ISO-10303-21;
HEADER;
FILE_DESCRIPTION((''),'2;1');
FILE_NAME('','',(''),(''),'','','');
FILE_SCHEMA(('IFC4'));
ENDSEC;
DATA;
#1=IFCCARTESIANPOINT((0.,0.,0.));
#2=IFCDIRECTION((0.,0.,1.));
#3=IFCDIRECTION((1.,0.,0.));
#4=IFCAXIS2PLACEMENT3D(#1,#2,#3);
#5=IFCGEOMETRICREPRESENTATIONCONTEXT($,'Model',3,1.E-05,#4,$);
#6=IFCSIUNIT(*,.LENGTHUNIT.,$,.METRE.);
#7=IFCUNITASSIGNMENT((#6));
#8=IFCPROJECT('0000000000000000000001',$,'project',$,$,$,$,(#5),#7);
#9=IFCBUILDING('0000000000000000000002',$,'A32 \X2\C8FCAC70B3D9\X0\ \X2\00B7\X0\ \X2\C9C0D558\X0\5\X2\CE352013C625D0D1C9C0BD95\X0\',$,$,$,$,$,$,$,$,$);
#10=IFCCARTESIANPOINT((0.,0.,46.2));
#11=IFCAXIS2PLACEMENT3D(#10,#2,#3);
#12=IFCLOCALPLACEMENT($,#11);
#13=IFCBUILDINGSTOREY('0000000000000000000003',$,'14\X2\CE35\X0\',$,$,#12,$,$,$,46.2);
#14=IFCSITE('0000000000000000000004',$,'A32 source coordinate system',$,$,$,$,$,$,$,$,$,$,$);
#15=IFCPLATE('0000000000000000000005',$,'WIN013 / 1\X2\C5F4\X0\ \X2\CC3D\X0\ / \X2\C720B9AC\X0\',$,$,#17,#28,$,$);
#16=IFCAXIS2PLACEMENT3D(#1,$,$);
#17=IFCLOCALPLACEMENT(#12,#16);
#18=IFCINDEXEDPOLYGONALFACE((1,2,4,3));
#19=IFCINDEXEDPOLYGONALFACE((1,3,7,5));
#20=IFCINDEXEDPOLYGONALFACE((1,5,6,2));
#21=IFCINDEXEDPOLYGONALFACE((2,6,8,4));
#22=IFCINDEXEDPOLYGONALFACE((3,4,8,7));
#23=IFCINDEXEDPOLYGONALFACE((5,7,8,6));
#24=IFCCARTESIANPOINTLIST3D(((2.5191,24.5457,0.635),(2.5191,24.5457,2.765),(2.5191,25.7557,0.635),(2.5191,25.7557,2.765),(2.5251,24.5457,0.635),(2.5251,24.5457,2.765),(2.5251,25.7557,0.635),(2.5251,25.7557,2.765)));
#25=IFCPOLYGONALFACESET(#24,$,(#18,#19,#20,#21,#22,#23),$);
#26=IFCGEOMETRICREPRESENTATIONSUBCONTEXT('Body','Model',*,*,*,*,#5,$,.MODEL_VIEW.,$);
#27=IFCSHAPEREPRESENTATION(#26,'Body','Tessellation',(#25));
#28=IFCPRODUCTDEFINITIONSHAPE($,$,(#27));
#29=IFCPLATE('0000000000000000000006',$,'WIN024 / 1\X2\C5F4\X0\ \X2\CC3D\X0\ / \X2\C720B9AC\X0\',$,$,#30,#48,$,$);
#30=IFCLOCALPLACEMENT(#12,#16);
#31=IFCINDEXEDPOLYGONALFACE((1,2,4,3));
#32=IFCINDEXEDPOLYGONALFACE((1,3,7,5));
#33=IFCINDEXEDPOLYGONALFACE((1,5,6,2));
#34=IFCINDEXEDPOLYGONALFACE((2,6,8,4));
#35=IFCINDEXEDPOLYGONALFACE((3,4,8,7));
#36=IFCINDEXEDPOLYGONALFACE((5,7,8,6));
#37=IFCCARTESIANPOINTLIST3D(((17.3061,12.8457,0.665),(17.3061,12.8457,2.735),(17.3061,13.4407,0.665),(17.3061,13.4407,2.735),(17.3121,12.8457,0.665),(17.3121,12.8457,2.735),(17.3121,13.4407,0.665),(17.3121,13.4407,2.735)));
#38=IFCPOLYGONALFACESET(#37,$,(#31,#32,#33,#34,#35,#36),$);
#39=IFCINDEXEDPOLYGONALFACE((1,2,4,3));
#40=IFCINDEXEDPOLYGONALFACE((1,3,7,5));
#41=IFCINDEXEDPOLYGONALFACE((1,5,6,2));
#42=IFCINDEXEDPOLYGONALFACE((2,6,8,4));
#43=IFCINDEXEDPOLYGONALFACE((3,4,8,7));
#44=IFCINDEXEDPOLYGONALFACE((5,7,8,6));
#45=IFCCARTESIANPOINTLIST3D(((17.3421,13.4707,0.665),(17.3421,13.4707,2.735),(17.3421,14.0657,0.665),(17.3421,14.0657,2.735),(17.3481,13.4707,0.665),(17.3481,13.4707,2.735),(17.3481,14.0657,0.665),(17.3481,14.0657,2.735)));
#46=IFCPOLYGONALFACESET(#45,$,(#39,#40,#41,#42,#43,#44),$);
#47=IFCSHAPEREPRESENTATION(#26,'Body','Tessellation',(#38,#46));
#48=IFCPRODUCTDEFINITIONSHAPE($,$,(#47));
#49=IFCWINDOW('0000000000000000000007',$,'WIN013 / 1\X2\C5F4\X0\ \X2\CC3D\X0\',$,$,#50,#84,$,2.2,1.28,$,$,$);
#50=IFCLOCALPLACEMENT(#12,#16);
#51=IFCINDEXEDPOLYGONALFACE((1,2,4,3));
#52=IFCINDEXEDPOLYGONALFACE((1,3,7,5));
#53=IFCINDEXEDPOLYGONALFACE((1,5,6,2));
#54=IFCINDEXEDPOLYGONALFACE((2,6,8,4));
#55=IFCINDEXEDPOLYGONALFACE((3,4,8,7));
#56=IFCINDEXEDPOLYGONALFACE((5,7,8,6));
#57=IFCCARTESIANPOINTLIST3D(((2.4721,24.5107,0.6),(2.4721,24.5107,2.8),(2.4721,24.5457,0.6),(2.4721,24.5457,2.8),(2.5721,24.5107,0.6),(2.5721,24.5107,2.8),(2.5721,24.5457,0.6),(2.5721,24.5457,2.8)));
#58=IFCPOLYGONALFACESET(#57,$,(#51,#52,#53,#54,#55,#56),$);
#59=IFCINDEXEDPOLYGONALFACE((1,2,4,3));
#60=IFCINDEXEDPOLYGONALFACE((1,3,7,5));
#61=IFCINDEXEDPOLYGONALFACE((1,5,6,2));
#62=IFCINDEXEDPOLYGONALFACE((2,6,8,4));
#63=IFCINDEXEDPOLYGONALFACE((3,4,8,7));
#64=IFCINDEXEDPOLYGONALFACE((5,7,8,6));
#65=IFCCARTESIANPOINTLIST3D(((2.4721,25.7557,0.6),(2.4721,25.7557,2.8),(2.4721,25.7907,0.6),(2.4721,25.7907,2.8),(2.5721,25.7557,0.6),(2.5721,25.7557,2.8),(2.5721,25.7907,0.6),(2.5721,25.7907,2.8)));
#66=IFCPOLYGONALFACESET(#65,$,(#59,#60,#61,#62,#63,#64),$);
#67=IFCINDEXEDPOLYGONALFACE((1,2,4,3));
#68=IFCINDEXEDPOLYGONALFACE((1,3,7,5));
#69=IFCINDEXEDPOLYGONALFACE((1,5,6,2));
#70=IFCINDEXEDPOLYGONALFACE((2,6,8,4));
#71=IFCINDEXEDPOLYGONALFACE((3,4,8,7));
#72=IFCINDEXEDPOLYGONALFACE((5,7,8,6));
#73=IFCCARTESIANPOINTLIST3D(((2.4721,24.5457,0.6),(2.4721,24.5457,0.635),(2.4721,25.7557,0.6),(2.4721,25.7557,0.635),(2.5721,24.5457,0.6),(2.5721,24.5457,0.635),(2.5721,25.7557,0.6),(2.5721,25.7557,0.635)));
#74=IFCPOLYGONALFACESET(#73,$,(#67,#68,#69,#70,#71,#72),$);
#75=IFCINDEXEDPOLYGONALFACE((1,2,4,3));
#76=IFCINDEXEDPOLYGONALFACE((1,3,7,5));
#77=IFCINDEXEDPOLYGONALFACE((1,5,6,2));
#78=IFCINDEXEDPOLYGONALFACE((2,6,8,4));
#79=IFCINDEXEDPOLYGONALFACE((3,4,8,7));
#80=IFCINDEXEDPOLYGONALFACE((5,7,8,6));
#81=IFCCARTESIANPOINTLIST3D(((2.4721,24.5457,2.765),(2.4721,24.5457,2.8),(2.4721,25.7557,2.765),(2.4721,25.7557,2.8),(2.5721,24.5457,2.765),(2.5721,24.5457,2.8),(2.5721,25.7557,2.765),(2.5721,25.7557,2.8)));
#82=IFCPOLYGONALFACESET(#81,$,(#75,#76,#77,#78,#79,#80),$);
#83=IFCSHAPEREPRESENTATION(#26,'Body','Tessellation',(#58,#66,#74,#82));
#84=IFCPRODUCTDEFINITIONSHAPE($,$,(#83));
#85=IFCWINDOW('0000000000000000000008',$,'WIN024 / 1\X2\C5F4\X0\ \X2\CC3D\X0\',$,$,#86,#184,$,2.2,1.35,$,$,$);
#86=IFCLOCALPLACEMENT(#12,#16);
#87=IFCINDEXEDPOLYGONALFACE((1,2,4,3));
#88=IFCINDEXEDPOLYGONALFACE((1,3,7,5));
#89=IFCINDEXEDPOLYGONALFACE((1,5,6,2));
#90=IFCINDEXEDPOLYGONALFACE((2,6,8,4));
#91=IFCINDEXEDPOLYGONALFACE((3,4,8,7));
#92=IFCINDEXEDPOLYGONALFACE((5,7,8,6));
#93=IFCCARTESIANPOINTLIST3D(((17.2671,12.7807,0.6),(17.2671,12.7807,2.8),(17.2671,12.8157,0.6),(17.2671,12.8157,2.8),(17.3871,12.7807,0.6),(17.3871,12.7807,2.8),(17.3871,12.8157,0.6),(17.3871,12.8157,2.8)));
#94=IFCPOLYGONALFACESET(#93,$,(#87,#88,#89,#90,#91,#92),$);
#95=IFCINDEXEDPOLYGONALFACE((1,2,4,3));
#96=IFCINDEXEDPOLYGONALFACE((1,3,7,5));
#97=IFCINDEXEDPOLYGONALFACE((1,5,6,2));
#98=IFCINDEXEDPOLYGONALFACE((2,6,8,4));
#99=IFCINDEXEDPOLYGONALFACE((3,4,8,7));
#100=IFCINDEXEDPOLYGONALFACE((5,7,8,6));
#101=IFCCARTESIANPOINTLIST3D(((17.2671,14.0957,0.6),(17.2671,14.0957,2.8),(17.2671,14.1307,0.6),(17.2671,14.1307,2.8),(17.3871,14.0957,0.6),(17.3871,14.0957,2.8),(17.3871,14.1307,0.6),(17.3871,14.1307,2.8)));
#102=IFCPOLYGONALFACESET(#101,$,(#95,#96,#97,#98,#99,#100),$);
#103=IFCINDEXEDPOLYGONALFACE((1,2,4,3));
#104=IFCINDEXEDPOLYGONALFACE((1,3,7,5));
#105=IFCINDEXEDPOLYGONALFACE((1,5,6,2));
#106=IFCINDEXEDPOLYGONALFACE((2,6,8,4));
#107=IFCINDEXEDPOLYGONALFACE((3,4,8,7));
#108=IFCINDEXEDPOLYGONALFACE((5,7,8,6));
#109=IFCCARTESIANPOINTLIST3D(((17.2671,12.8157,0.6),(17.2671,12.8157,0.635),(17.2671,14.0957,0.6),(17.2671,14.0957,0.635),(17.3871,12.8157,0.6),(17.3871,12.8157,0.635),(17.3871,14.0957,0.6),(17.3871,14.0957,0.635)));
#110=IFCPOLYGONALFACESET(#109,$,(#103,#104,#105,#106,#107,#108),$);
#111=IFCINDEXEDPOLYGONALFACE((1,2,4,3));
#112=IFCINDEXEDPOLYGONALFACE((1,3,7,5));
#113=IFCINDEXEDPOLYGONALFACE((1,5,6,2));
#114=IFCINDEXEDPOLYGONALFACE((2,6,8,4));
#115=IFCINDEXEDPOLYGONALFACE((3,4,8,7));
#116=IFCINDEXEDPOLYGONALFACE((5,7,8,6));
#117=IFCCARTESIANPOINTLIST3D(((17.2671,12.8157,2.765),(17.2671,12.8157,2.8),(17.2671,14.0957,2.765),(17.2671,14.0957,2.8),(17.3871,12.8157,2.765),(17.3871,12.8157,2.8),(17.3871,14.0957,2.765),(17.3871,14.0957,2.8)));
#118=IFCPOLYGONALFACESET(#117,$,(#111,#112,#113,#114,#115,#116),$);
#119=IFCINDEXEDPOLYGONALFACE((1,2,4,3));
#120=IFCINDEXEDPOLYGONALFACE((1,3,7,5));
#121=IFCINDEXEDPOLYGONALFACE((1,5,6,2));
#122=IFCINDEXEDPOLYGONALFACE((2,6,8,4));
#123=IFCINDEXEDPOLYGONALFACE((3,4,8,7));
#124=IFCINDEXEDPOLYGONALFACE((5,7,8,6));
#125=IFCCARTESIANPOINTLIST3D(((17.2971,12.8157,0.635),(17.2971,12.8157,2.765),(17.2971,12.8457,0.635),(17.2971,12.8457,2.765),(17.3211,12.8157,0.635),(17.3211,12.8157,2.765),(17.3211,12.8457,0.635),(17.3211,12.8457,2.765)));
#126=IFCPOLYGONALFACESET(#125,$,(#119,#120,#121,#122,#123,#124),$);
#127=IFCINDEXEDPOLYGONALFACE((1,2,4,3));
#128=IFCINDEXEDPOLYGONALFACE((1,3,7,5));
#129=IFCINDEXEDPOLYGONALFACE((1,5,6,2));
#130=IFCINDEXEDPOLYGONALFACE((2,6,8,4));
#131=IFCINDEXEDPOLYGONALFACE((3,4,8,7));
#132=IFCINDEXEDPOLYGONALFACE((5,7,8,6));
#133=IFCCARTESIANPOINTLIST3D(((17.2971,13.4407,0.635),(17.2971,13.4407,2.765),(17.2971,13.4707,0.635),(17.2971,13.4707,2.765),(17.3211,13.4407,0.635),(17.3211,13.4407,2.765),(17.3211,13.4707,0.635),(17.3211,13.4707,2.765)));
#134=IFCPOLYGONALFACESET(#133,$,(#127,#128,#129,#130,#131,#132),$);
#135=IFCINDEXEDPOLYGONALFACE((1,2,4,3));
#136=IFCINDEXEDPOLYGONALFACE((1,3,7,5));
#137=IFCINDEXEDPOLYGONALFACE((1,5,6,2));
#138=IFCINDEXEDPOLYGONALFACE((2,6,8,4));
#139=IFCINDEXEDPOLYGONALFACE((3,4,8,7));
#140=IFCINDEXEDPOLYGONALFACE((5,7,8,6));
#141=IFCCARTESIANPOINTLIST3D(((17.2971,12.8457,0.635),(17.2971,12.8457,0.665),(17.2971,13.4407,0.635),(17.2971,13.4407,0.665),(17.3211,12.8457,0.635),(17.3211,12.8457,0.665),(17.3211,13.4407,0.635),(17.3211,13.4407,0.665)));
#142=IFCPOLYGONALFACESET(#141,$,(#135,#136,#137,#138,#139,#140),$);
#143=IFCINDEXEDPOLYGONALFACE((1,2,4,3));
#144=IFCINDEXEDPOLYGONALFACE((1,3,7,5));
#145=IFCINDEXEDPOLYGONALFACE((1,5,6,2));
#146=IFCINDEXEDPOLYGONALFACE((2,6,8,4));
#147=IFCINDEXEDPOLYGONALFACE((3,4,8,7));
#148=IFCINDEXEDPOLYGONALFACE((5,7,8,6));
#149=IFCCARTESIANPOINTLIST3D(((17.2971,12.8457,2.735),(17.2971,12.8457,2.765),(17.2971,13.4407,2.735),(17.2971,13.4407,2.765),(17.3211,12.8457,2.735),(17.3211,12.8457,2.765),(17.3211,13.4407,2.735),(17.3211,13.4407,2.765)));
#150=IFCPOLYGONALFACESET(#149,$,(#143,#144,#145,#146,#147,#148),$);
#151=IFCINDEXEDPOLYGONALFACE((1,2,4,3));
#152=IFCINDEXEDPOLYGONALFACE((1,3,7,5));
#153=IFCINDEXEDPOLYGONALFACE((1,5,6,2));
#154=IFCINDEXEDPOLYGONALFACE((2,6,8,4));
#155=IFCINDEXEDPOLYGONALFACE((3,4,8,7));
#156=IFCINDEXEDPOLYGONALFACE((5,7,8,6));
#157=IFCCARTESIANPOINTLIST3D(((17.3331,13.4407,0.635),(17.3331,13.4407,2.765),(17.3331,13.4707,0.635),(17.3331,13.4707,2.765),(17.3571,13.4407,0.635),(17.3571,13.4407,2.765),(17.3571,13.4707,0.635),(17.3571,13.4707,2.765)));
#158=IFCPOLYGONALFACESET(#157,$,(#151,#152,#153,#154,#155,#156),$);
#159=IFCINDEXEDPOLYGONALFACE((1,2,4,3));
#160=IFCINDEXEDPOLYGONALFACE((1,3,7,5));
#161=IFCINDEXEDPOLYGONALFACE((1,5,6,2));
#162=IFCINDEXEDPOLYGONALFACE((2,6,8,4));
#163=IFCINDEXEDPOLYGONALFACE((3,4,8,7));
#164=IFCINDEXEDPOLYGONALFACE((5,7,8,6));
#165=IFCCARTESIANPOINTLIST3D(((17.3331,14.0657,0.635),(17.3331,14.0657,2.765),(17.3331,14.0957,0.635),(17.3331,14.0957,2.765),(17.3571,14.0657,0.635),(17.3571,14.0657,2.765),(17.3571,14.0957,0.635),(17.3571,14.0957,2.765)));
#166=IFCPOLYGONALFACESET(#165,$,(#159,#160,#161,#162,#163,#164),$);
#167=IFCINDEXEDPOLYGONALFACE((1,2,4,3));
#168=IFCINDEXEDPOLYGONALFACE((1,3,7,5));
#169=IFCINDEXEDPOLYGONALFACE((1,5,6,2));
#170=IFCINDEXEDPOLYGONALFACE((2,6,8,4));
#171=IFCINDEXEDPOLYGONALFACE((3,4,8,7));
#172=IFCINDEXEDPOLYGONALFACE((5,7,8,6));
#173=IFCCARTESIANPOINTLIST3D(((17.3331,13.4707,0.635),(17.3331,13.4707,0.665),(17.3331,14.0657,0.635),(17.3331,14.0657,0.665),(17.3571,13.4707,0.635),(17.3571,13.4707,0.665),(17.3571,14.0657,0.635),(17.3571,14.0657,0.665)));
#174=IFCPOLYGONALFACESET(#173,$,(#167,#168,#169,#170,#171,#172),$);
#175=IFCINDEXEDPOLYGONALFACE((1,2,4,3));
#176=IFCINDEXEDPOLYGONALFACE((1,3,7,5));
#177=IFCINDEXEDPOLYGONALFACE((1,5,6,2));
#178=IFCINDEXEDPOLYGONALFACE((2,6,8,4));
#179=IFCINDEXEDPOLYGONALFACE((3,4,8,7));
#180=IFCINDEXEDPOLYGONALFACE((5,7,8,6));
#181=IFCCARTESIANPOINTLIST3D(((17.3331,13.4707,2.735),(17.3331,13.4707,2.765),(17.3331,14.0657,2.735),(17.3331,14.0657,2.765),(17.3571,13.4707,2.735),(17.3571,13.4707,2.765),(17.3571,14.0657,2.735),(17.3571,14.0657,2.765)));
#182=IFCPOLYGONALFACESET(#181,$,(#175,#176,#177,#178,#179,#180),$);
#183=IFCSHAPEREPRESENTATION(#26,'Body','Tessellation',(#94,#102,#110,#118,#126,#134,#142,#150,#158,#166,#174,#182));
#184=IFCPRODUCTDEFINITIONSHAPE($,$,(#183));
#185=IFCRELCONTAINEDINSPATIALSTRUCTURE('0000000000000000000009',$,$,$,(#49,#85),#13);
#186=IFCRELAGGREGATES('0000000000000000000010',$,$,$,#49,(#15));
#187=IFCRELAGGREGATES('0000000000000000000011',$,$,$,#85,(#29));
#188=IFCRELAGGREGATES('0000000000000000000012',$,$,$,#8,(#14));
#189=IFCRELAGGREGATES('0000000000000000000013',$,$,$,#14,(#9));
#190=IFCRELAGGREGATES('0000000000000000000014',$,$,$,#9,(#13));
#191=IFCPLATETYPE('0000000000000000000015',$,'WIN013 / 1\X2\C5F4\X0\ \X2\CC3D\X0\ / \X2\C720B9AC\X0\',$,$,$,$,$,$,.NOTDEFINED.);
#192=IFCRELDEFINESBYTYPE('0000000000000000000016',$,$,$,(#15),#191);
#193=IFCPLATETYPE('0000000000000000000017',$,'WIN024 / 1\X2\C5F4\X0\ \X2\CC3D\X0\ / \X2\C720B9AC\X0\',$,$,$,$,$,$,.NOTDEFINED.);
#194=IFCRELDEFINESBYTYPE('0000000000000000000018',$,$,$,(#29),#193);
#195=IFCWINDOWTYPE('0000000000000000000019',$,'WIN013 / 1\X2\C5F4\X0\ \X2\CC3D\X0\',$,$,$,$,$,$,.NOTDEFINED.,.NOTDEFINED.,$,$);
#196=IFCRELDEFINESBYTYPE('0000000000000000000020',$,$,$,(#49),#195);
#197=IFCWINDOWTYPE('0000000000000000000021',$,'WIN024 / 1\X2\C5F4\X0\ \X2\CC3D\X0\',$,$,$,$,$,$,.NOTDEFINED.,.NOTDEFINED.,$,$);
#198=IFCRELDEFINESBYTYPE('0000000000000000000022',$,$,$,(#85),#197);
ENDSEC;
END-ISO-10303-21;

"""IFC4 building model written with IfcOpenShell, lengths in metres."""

from ifc_helpers import new_model, si_unit, frame, origin, origin_with_axes, place, context, subcontext, project, spatial, polyline, outline, extrude, source, transform, mapped, type_object, type_shapes, element, aggregate, save


model = new_model("IFC4")

# Units and contexts
model_context = context("Model", 3, precision=1e-05, world=origin_with_axes())
body_context = subcontext(model_context, "Body", "Model", "MODEL_VIEW")
ifc_project = project(units=[si_unit("LENGTHUNIT", "METRE")], contexts=[model_context])

# Plates
plate_type_1 = type_object("IfcPlateType", Name="WIN013 / 1열 창 / 유리", PredefinedType="NOTDEFINED")
shared_shape_1 = source(origin(), body_context, "Body", "SweptSolid", [
    extrude(outline(polyline([(2.5191, 24.5457), (2.5191, 25.7557), (2.5251, 25.7557), (2.5251, 24.5457), (2.5191, 24.5457)])), frame((0.0, 0.0, 0.635)), (0.0, 0.0, 1.0), 2.13),
])
type_shapes(plate_type_1, [shared_shape_1])
storey_placement = place(None, frame((0.0, 0.0, 46.2), z_axis=(0.0, 0.0, 1.0), x_axis=(1.0, 0.0, 0.0)))
window_1_placement = place(storey_placement, origin_with_axes())
plate_1_placement = place(window_1_placement, origin_with_axes())
plate_1 = element("IfcPlate", 1, at=plate_1_placement, type_object=plate_type_1, Name="WIN013 / 1열 창 / 유리", context=body_context, shape_type="MappedRepresentation", body=[
    mapped(shared_shape_1, transform((0.0, 0.0, 0.0), scale=1.0)),
])
plate_type_2 = type_object("IfcPlateType", Name="WIN024 / 1열 창 / 유리", PredefinedType="NOTDEFINED")
shared_shape_2 = source(origin(), body_context, "Body", "SweptSolid", [
    extrude(outline(polyline([(17.3061, 12.8457), (17.3061, 13.4407), (17.3121, 13.4407), (17.3121, 12.8457), (17.3061, 12.8457)])), frame((0.0, 0.0, 0.665)), (0.0, 0.0, 1.0), 2.07),
    extrude(outline(polyline([(17.3421, 13.4707), (17.3421, 14.0657), (17.3481, 14.0657), (17.3481, 13.4707), (17.3421, 13.4707)])), frame((0.0, 0.0, 0.665)), (0.0, 0.0, 1.0), 2.07),
])
type_shapes(plate_type_2, [shared_shape_2])
window_2_placement = place(storey_placement, origin_with_axes())
plate_2_placement = place(window_2_placement, origin_with_axes())
plate_2 = element("IfcPlate", 2, at=plate_2_placement, type_object=plate_type_2, Name="WIN024 / 1열 창 / 유리", context=body_context, shape_type="MappedRepresentation", body=[
    mapped(shared_shape_2, transform((0.0, 0.0, 0.0), scale=1.0)),
])

# Site, building, storey
site = spatial("IfcSite", under=ifc_project, Name="A32 source coordinate system")
building = spatial("IfcBuilding", under=site, Name="A32 주거동 · 지하5층–옥탑지붕")
storey = spatial("IfcBuildingStorey", under=building, at=storey_placement, Name="14층", Elevation=46.2)

# Windows
window_type_1 = type_object("IfcWindowType", Name="WIN013 / 1열 창", PartitioningType="NOTDEFINED", PredefinedType="NOTDEFINED")
shared_shape_3 = source(origin(), body_context, "Body", "SweptSolid", [
    extrude(outline(polyline([(2.4721, 24.5107), (2.4721, 24.5457), (2.5721, 24.5457), (2.5721, 24.5107), (2.4721, 24.5107)])), frame((0.0, 0.0, 0.6)), (0.0, 0.0, 1.0), 2.2),
    extrude(outline(polyline([(2.4721, 25.7557), (2.4721, 25.7907), (2.5721, 25.7907), (2.5721, 25.7557), (2.4721, 25.7557)])), frame((0.0, 0.0, 0.6)), (0.0, 0.0, 1.0), 2.2),
    extrude(outline(polyline([(2.4721, 24.5457), (2.4721, 25.7557), (2.5721, 25.7557), (2.5721, 24.5457), (2.4721, 24.5457)])), frame((0.0, 0.0, 0.6)), (0.0, 0.0, 1.0), 0.035),
    extrude(outline(polyline([(2.4721, 24.5457), (2.4721, 25.7557), (2.5721, 25.7557), (2.5721, 24.5457), (2.4721, 24.5457)])), frame((0.0, 0.0, 2.765)), (0.0, 0.0, 1.0), 0.035),
])
type_shapes(window_type_1, [shared_shape_3])
window_1 = element("IfcWindow", 3, at=window_1_placement, inside=storey, type_object=window_type_1, Name="WIN013 / 1열 창", OverallHeight=2.2, OverallWidth=1.28, context=body_context, shape_type="MappedRepresentation", body=[
    mapped(shared_shape_3, transform((0.0, 0.0, 0.0), scale=1.0)),
])
aggregate(window_1, [plate_1])
window_type_2 = type_object("IfcWindowType", Name="WIN024 / 1열 창", PartitioningType="NOTDEFINED", PredefinedType="NOTDEFINED")
shared_shape_4 = source(origin(), body_context, "Body", "SweptSolid", [
    extrude(outline(polyline([(17.2671, 12.7807), (17.2671, 12.8157), (17.3871, 12.8157), (17.3871, 12.7807), (17.2671, 12.7807)])), frame((0.0, 0.0, 0.6)), (0.0, 0.0, 1.0), 2.2),
    extrude(outline(polyline([(17.2671, 14.0957), (17.2671, 14.1307), (17.3871, 14.1307), (17.3871, 14.0957), (17.2671, 14.0957)])), frame((0.0, 0.0, 0.6)), (0.0, 0.0, 1.0), 2.2),
    extrude(outline(polyline([(17.2671, 12.8157), (17.2671, 14.0957), (17.3871, 14.0957), (17.3871, 12.8157), (17.2671, 12.8157)])), frame((0.0, 0.0, 0.6)), (0.0, 0.0, 1.0), 0.035),
    extrude(outline(polyline([(17.2671, 12.8157), (17.2671, 14.0957), (17.3871, 14.0957), (17.3871, 12.8157), (17.2671, 12.8157)])), frame((0.0, 0.0, 2.765)), (0.0, 0.0, 1.0), 0.035),
    extrude(outline(polyline([(17.2971, 12.8157), (17.2971, 12.8457), (17.3211, 12.8457), (17.3211, 12.8157), (17.2971, 12.8157)])), frame((0.0, 0.0, 0.635)), (0.0, 0.0, 1.0), 2.13),
    extrude(outline(polyline([(17.2971, 13.4407), (17.2971, 13.4707), (17.3211, 13.4707), (17.3211, 13.4407), (17.2971, 13.4407)])), frame((0.0, 0.0, 0.635)), (0.0, 0.0, 1.0), 2.13),
    extrude(outline(polyline([(17.2971, 12.8457), (17.2971, 13.4407), (17.3211, 13.4407), (17.3211, 12.8457), (17.2971, 12.8457)])), frame((0.0, 0.0, 0.635)), (0.0, 0.0, 1.0), 0.03),
    extrude(outline(polyline([(17.2971, 12.8457), (17.2971, 13.4407), (17.3211, 13.4407), (17.3211, 12.8457), (17.2971, 12.8457)])), frame((0.0, 0.0, 2.735)), (0.0, 0.0, 1.0), 0.03),
    extrude(outline(polyline([(17.3331, 13.4407), (17.3331, 13.4707), (17.3571, 13.4707), (17.3571, 13.4407), (17.3331, 13.4407)])), frame((0.0, 0.0, 0.635)), (0.0, 0.0, 1.0), 2.13),
    extrude(outline(polyline([(17.3331, 14.0657), (17.3331, 14.0957), (17.3571, 14.0957), (17.3571, 14.0657), (17.3331, 14.0657)])), frame((0.0, 0.0, 0.635)), (0.0, 0.0, 1.0), 2.13),
    extrude(outline(polyline([(17.3331, 13.4707), (17.3331, 14.0657), (17.3571, 14.0657), (17.3571, 13.4707), (17.3331, 13.4707)])), frame((0.0, 0.0, 0.635)), (0.0, 0.0, 1.0), 0.03),
    extrude(outline(polyline([(17.3331, 13.4707), (17.3331, 14.0657), (17.3571, 14.0657), (17.3571, 13.4707), (17.3331, 13.4707)])), frame((0.0, 0.0, 2.735)), (0.0, 0.0, 1.0), 0.03),
])
type_shapes(window_type_2, [shared_shape_4])
window_2 = element("IfcWindow", 4, at=window_2_placement, inside=storey, type_object=window_type_2, Name="WIN024 / 1열 창", OverallHeight=2.2, OverallWidth=1.35, context=body_context, shape_type="MappedRepresentation", body=[
    mapped(shared_shape_4, transform((0.0, 0.0, 0.0), scale=1.0)),
])
aggregate(window_2, [plate_2])

save(model, "model.ifc")
